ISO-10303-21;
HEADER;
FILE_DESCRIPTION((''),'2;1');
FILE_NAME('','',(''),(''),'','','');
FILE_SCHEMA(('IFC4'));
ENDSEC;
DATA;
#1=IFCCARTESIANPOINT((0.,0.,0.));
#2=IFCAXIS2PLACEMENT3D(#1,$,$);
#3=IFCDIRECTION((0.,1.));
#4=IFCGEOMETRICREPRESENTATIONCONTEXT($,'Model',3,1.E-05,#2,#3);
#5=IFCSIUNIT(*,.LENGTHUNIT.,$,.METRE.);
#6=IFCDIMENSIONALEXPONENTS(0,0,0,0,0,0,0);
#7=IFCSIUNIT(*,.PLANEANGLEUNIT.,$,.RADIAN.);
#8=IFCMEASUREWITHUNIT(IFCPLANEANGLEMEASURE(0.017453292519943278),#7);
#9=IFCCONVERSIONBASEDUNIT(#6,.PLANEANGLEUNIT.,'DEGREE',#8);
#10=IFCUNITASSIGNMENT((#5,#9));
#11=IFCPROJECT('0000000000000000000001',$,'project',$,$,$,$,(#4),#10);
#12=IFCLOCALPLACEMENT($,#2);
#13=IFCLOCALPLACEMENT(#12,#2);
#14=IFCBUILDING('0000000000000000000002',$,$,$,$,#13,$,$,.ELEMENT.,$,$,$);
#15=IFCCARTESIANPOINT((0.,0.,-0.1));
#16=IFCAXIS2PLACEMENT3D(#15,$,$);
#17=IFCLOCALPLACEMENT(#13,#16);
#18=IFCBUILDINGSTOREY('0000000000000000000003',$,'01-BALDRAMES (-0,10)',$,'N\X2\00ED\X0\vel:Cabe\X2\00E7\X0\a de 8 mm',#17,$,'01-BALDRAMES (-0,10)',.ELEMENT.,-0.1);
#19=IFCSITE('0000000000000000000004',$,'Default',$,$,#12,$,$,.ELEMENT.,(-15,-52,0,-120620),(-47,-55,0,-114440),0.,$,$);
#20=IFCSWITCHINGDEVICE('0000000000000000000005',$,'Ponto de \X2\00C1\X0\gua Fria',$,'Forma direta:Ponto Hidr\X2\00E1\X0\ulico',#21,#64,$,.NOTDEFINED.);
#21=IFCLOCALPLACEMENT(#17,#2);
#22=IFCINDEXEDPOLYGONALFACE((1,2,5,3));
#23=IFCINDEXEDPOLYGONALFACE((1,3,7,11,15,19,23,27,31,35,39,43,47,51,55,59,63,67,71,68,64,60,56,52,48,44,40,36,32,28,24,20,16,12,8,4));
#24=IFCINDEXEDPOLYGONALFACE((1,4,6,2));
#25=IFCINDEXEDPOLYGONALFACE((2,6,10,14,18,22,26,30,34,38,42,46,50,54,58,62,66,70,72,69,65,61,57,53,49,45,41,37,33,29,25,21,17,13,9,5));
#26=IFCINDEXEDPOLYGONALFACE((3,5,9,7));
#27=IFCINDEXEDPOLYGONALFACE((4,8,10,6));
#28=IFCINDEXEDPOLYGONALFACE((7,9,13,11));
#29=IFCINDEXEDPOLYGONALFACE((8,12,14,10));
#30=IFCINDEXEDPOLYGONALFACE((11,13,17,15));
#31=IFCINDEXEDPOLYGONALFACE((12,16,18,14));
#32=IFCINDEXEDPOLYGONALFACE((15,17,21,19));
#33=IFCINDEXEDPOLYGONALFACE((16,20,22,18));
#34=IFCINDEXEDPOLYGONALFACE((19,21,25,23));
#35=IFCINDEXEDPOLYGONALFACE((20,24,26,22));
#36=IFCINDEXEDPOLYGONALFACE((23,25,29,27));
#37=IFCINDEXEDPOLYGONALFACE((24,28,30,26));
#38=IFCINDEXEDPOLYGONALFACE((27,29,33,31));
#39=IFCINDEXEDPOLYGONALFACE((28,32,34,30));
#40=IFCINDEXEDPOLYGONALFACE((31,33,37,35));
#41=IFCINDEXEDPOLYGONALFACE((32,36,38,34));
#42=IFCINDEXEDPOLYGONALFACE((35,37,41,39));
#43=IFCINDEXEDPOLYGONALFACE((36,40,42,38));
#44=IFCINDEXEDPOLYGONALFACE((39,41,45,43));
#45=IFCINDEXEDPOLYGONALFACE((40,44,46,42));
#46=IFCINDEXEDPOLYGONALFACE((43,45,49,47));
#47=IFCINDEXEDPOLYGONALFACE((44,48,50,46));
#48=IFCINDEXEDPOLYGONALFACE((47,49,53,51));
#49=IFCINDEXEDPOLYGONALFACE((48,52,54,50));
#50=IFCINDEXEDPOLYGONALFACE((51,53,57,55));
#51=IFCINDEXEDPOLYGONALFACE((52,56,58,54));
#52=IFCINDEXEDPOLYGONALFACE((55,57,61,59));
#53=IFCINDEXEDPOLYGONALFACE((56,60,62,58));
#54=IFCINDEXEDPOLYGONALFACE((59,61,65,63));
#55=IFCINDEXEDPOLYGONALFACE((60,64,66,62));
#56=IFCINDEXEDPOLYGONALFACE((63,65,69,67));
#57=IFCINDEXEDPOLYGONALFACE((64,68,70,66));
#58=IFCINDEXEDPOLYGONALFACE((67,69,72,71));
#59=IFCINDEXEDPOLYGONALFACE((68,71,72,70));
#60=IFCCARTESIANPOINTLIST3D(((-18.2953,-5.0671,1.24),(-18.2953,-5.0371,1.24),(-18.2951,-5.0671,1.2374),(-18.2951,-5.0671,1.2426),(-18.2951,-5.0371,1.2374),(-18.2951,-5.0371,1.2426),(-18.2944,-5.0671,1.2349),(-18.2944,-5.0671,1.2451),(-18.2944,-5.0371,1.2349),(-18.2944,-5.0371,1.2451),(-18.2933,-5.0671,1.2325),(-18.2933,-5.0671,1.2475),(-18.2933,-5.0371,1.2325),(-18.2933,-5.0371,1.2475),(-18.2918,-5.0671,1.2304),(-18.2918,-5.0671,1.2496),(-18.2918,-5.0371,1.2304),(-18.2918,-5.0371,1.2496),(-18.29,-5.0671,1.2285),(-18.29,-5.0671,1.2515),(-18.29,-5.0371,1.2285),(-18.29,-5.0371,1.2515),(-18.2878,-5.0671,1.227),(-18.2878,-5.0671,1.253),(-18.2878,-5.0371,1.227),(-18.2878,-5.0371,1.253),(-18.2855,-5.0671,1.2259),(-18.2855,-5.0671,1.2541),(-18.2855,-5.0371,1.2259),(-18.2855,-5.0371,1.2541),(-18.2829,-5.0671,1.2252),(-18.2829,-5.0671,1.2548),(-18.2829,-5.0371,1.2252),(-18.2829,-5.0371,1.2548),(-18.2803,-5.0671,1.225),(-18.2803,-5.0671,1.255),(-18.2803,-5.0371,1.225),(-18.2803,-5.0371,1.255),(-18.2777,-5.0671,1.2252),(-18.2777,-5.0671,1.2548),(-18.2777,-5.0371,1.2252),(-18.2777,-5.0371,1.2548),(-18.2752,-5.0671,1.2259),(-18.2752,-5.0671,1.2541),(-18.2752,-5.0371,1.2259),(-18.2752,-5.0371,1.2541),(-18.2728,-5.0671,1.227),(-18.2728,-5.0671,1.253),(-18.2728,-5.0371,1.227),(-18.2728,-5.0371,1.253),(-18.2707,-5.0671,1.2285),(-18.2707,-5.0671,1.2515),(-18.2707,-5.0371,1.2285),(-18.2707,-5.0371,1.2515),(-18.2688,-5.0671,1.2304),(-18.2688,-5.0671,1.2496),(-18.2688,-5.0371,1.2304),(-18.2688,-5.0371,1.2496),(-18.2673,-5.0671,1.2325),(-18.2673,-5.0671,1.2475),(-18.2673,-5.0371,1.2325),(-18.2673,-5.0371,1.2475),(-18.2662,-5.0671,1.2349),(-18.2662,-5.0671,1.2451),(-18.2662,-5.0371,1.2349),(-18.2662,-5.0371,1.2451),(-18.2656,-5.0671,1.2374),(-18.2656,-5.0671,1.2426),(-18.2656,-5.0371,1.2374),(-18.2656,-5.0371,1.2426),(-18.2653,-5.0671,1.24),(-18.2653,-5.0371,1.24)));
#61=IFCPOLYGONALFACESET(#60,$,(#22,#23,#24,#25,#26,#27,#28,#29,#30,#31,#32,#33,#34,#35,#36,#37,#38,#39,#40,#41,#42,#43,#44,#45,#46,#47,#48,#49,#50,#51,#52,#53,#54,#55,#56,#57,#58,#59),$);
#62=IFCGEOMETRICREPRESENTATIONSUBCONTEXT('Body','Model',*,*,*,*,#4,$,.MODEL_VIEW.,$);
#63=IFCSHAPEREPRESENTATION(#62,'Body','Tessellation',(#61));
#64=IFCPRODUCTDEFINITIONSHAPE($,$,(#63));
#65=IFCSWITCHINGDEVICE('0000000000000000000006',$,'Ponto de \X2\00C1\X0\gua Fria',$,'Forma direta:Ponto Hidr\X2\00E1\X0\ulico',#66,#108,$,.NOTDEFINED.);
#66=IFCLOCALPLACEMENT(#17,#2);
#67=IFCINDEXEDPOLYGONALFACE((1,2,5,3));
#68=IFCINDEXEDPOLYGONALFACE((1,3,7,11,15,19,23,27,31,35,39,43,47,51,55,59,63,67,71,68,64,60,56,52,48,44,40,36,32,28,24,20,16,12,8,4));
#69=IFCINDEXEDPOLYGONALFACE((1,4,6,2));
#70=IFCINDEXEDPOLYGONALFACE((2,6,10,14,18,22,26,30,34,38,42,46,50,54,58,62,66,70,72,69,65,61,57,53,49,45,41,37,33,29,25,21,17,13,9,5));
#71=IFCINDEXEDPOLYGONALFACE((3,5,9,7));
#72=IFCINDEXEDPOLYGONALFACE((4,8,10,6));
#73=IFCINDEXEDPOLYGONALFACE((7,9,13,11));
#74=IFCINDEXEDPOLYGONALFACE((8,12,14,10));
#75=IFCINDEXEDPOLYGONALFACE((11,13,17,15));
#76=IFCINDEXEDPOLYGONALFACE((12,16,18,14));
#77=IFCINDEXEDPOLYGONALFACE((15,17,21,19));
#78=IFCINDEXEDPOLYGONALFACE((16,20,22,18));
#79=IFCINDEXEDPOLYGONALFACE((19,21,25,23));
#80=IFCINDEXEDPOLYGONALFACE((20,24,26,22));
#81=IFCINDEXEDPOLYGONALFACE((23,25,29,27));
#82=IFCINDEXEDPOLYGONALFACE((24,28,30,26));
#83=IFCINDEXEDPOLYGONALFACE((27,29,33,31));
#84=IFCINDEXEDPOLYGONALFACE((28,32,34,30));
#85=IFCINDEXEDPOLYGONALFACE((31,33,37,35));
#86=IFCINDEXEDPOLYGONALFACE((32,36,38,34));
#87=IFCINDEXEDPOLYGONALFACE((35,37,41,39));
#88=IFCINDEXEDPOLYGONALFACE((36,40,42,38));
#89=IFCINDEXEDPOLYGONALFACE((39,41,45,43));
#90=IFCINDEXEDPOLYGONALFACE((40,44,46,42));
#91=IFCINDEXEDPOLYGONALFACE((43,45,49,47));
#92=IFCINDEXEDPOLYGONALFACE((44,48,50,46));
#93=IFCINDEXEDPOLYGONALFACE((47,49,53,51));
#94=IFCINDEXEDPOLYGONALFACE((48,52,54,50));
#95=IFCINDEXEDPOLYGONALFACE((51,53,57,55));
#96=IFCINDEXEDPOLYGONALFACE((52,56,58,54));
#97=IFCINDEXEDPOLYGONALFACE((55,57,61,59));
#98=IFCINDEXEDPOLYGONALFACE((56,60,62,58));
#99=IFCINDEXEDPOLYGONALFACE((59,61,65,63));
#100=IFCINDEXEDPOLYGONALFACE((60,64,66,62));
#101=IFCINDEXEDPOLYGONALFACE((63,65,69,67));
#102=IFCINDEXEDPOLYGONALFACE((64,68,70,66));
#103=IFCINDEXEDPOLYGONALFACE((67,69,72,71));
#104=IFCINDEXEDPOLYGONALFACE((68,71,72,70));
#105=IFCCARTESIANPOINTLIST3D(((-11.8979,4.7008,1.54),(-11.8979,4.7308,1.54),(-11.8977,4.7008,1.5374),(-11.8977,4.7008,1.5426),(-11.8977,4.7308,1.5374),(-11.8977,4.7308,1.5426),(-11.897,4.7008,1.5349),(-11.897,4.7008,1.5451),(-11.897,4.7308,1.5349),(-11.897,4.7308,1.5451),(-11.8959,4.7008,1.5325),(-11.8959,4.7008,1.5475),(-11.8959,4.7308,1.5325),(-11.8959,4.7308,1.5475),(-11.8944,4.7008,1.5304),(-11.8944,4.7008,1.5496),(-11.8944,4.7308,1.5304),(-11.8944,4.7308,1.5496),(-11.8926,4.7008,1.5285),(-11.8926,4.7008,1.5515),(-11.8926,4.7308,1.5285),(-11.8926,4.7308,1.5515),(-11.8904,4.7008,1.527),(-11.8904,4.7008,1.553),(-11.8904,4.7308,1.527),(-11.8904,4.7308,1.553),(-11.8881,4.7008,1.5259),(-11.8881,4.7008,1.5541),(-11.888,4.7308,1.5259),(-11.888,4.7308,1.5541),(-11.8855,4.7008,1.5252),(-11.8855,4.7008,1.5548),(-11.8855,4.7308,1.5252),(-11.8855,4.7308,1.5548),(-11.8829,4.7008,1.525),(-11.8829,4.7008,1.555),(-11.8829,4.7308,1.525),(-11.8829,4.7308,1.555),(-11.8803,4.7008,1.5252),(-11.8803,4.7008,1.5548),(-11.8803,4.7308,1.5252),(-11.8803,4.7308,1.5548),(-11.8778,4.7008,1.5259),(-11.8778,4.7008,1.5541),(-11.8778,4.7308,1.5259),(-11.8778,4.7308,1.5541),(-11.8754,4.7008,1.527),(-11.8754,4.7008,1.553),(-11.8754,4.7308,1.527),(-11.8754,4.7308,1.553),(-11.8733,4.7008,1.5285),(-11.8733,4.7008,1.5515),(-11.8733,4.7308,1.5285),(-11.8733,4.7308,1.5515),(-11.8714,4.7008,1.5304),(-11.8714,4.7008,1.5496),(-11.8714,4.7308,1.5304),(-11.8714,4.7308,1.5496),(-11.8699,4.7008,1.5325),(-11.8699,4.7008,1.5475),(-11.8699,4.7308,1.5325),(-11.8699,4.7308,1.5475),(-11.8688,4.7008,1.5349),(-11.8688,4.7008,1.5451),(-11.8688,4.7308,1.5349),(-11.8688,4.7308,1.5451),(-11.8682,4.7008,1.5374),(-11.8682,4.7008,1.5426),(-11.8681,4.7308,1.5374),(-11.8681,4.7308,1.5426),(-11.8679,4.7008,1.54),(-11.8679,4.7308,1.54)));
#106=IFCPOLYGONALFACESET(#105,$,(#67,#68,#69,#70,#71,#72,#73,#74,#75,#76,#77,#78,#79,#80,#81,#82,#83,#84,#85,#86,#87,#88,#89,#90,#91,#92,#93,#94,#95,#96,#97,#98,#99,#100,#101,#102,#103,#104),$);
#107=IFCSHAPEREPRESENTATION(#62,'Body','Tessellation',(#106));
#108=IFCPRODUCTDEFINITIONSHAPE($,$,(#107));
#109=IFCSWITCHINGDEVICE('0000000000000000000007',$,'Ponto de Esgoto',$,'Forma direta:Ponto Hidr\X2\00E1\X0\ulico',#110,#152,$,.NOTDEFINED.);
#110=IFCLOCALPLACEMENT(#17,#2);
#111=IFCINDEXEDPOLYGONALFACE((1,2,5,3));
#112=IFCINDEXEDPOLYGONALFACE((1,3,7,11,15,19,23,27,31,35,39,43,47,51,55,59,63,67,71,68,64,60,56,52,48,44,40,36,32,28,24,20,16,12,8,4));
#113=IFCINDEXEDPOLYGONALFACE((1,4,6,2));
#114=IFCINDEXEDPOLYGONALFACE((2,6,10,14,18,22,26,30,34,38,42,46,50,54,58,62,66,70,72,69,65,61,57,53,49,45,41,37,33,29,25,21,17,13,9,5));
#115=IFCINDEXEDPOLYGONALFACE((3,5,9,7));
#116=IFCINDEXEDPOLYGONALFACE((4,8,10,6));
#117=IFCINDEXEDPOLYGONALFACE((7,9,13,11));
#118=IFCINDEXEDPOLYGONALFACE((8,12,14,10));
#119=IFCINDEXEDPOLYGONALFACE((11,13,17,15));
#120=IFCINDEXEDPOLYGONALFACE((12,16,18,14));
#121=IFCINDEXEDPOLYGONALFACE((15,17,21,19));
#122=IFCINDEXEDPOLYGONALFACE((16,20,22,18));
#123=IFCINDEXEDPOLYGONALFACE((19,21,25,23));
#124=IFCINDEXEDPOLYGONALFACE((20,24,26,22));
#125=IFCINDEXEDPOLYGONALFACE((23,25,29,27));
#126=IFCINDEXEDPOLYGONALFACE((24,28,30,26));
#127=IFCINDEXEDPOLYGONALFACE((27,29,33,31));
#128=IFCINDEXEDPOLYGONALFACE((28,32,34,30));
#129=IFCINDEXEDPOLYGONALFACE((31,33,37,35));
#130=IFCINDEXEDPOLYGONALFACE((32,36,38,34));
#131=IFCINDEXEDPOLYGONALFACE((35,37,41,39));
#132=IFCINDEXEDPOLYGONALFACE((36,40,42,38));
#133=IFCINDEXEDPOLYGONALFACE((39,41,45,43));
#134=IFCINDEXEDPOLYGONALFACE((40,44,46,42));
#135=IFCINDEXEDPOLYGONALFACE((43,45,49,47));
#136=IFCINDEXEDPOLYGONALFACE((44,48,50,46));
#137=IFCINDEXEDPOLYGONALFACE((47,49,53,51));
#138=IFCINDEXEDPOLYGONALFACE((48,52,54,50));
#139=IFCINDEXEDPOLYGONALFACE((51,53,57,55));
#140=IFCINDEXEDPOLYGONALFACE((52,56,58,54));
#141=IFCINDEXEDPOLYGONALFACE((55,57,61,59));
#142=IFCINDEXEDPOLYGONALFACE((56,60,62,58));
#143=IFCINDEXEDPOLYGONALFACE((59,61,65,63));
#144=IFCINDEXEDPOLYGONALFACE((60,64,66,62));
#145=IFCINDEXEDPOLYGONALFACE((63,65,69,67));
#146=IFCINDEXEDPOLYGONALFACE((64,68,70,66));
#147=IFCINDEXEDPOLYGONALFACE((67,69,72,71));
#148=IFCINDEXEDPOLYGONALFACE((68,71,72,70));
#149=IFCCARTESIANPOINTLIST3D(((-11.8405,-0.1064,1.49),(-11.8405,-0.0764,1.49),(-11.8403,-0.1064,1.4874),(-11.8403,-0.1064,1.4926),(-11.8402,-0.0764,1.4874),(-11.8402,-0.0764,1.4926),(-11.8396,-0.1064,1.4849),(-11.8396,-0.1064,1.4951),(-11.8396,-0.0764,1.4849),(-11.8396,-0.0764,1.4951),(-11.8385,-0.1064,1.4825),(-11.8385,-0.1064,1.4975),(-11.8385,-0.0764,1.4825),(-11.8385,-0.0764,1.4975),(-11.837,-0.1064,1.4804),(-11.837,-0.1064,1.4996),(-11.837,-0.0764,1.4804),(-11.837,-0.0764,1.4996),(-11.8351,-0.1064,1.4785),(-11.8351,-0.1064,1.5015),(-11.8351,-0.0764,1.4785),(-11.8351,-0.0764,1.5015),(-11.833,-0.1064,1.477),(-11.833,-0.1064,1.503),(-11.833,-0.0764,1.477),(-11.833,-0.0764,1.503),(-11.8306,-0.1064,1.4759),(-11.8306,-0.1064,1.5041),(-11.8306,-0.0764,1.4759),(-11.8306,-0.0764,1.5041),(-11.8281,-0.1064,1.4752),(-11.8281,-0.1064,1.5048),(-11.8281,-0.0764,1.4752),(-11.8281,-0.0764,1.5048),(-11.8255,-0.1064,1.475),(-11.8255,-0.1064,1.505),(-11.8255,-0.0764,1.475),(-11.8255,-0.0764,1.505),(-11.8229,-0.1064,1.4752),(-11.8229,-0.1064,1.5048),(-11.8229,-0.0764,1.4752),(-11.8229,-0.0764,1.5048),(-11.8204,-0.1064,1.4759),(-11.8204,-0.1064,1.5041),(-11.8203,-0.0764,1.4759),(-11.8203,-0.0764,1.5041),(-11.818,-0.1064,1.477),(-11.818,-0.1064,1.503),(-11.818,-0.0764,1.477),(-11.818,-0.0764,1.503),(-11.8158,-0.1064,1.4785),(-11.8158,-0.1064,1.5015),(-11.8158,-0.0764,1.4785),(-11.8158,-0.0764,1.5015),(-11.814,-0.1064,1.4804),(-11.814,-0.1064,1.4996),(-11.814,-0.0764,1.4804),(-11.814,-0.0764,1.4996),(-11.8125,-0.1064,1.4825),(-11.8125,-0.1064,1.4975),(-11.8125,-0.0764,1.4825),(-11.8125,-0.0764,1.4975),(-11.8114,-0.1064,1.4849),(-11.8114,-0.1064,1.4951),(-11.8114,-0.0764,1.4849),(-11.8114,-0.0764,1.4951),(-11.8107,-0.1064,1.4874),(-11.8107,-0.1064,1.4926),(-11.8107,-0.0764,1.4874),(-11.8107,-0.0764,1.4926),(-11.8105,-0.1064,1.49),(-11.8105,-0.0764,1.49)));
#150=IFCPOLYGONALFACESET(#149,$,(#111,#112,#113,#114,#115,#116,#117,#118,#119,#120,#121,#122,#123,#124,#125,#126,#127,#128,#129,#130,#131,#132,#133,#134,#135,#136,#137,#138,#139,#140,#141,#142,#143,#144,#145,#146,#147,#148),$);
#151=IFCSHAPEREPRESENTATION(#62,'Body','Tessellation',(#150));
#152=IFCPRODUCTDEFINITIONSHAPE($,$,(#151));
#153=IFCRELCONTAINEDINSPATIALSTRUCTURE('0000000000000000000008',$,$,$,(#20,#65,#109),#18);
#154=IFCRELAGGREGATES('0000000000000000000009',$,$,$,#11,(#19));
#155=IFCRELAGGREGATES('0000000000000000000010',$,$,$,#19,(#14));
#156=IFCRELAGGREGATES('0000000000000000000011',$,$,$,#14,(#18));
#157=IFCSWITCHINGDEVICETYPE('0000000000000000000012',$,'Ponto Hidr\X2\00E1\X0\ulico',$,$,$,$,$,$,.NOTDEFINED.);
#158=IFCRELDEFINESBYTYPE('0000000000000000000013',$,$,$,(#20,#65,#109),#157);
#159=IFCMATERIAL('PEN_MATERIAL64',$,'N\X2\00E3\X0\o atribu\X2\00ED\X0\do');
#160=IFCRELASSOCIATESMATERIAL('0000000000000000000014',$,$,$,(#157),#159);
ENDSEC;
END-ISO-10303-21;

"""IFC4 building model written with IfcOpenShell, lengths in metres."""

from ifc_helpers import new_model, entity, si_unit, converted_unit, direction, frame, origin, place, context, subcontext, project, spatial, indexed_curve, outline, extrude, material, type_object, element, save


model = new_model("IFC4")

# Units and contexts
model_context = context("Model", 3, precision=1e-05, world=origin(), true_north=direction((0.0, 1.0)))
body_context = subcontext(model_context, "Body", "Model", "MODEL_VIEW")
ifc_project = project(units=[si_unit("LENGTHUNIT", "METRE"), converted_unit("PLANEANGLEUNIT", "DEGREE", entity("IfcPlaneAngleMeasure", 0.017453292519943278), si_unit("PLANEANGLEUNIT", "RADIAN"), dimensions=[0, 0, 0, 0, 0, 0, 0])], contexts=[model_context])

# Site, building, storey
site_placement = place(None, origin())
site = spatial("IfcSite", under=ifc_project, at=site_placement, Name="Default", CompositionType="ELEMENT", RefLatitude=(-15, -52, 0, -120620), RefLongitude=(-47, -55, 0, -114440), RefElevation=0.0)
building_placement = place(site_placement, origin())
building = spatial("IfcBuilding", under=site, at=building_placement, CompositionType="ELEMENT")
storey_placement = place(building_placement, frame((0.0, 0.0, -0.1)))
storey = spatial("IfcBuildingStorey", under=building, at=storey_placement, Name="01-BALDRAMES (-0,10)", ObjectType="Nível:Cabeça de 8 mm", LongName="01-BALDRAMES (-0,10)", CompositionType="ELEMENT", Elevation=-0.1)

# Switching devices
ifc_material_1 = material(Name="PEN_MATERIAL64", Category="Não atribuído")
switching_device_type = type_object("IfcSwitchingDeviceType", Name="Ponto Hidráulico", PredefinedType="NOTDEFINED", material=ifc_material_1)
switching_device_1_placement = place(storey_placement, origin())
element("IfcSwitchingDevice", 1, at=switching_device_1_placement, inside=storey, type_object=switching_device_type, Name="Ponto de Água Fria", ObjectType="Forma direta:Ponto Hidráulico", PredefinedType="NOTDEFINED", context=body_context, shape_type="SweptSolid", body=[
    extrude(outline(indexed_curve([(-0.0013, -0.0149), (0.0013, -0.0149), (0.0039, -0.0145), (0.0063, -0.0136), (0.0086, -0.0123), (0.0106, -0.0106), (0.0123, -0.0086), (0.0136, -0.0063), (0.0145, -0.0039), (0.0149, -0.0013), (0.0149, 0.0013), (0.0145, 0.0039), (0.0136, 0.0063), (0.0123, 0.0086), (0.0106, 0.0106), (0.0086, 0.0123), (0.0063, 0.0136), (0.0039, 0.0145), (0.0013, 0.0149), (-0.0013, 0.0149), (-0.0039, 0.0145), (-0.0063, 0.0136), (-0.0086, 0.0123), (-0.0106, 0.0106), (-0.0123, 0.0086), (-0.0136, 0.0063), (-0.0145, 0.0039), (-0.0149, 0.0013), (-0.0149, -0.0013), (-0.0145, -0.0039), (-0.0136, -0.0063), (-0.0123, -0.0086), (-0.0106, -0.0106), (-0.0086, -0.0123), (-0.0063, -0.0136), (-0.0039, -0.0145), (-0.0013, -0.0149)], self_intersect=False)), frame((-18.2803, -5.0671, 1.24), z_axis=(0.000435, 1.0, 0.0), x_axis=(-0.965926, 0.00042, 0.258819)), (0.0, 0.0, 1.0), 0.03),
])
switching_device_2_placement = place(storey_placement, origin())
element("IfcSwitchingDevice", 2, at=switching_device_2_placement, inside=storey, type_object=switching_device_type, Name="Ponto de Água Fria", ObjectType="Forma direta:Ponto Hidráulico", PredefinedType="NOTDEFINED", context=body_context, shape_type="SweptSolid", body=[
    extrude(outline(indexed_curve([(-0.0013, -0.0149), (0.0013, -0.0149), (0.0039, -0.0145), (0.0063, -0.0136), (0.0086, -0.0123), (0.0106, -0.0106), (0.0123, -0.0086), (0.0136, -0.0063), (0.0145, -0.0039), (0.0149, -0.0013), (0.0149, 0.0013), (0.0145, 0.0039), (0.0136, 0.0063), (0.0123, 0.0086), (0.0106, 0.0106), (0.0086, 0.0123), (0.0063, 0.0136), (0.0039, 0.0145), (0.0013, 0.0149), (-0.0013, 0.0149), (-0.0039, 0.0145), (-0.0063, 0.0136), (-0.0086, 0.0123), (-0.0106, 0.0106), (-0.0123, 0.0086), (-0.0136, 0.0063), (-0.0145, 0.0039), (-0.0149, 0.0013), (-0.0149, -0.0013), (-0.0145, -0.0039), (-0.0136, -0.0063), (-0.0123, -0.0086), (-0.0106, -0.0106), (-0.0086, -0.0123), (-0.0063, -0.0136), (-0.0039, -0.0145), (-0.0013, -0.0149)], self_intersect=False)), frame((-11.8829, 4.7008, 1.54), z_axis=(0.000299, 1.0, 0.0), x_axis=(-0.996195, 0.000298, -0.087156)), (0.0, 0.0, 1.0), 0.03),
])
switching_device_3_placement = place(storey_placement, origin())
element("IfcSwitchingDevice", 3, at=switching_device_3_placement, inside=storey, type_object=switching_device_type, Name="Ponto de Esgoto", ObjectType="Forma direta:Ponto Hidráulico", PredefinedType="NOTDEFINED", context=body_context, shape_type="SweptSolid", body=[
    extrude(outline(indexed_curve([(-0.0013, -0.0149), (0.0013, -0.0149), (0.0039, -0.0145), (0.0063, -0.0136), (0.0086, -0.0123), (0.0106, -0.0106), (0.0123, -0.0086), (0.0136, -0.0063), (0.0145, -0.0039), (0.0149, -0.0013), (0.0149, 0.0013), (0.0145, 0.0039), (0.0136, 0.0063), (0.0123, 0.0086), (0.0106, 0.0106), (0.0086, 0.0123), (0.0063, 0.0136), (0.0039, 0.0145), (0.0013, 0.0149), (-0.0013, 0.0149), (-0.0039, 0.0145), (-0.0063, 0.0136), (-0.0086, 0.0123), (-0.0106, 0.0106), (-0.0123, 0.0086), (-0.0136, 0.0063), (-0.0145, 0.0039), (-0.0149, 0.0013), (-0.0149, -0.0013), (-0.0145, -0.0039), (-0.0136, -0.0063), (-0.0123, -0.0086), (-0.0106, -0.0106), (-0.0086, -0.0123), (-0.0063, -0.0136), (-0.0039, -0.0145), (-0.0013, -0.0149)], self_intersect=False)), frame((-11.8255, -0.1064, 1.49), z_axis=(0.000435, 1.0, 0.0), x_axis=(-0.965926, 0.00042, 0.258819)), (0.0, 0.0, 1.0), 0.03),
])

save(model, "model.ifc")
